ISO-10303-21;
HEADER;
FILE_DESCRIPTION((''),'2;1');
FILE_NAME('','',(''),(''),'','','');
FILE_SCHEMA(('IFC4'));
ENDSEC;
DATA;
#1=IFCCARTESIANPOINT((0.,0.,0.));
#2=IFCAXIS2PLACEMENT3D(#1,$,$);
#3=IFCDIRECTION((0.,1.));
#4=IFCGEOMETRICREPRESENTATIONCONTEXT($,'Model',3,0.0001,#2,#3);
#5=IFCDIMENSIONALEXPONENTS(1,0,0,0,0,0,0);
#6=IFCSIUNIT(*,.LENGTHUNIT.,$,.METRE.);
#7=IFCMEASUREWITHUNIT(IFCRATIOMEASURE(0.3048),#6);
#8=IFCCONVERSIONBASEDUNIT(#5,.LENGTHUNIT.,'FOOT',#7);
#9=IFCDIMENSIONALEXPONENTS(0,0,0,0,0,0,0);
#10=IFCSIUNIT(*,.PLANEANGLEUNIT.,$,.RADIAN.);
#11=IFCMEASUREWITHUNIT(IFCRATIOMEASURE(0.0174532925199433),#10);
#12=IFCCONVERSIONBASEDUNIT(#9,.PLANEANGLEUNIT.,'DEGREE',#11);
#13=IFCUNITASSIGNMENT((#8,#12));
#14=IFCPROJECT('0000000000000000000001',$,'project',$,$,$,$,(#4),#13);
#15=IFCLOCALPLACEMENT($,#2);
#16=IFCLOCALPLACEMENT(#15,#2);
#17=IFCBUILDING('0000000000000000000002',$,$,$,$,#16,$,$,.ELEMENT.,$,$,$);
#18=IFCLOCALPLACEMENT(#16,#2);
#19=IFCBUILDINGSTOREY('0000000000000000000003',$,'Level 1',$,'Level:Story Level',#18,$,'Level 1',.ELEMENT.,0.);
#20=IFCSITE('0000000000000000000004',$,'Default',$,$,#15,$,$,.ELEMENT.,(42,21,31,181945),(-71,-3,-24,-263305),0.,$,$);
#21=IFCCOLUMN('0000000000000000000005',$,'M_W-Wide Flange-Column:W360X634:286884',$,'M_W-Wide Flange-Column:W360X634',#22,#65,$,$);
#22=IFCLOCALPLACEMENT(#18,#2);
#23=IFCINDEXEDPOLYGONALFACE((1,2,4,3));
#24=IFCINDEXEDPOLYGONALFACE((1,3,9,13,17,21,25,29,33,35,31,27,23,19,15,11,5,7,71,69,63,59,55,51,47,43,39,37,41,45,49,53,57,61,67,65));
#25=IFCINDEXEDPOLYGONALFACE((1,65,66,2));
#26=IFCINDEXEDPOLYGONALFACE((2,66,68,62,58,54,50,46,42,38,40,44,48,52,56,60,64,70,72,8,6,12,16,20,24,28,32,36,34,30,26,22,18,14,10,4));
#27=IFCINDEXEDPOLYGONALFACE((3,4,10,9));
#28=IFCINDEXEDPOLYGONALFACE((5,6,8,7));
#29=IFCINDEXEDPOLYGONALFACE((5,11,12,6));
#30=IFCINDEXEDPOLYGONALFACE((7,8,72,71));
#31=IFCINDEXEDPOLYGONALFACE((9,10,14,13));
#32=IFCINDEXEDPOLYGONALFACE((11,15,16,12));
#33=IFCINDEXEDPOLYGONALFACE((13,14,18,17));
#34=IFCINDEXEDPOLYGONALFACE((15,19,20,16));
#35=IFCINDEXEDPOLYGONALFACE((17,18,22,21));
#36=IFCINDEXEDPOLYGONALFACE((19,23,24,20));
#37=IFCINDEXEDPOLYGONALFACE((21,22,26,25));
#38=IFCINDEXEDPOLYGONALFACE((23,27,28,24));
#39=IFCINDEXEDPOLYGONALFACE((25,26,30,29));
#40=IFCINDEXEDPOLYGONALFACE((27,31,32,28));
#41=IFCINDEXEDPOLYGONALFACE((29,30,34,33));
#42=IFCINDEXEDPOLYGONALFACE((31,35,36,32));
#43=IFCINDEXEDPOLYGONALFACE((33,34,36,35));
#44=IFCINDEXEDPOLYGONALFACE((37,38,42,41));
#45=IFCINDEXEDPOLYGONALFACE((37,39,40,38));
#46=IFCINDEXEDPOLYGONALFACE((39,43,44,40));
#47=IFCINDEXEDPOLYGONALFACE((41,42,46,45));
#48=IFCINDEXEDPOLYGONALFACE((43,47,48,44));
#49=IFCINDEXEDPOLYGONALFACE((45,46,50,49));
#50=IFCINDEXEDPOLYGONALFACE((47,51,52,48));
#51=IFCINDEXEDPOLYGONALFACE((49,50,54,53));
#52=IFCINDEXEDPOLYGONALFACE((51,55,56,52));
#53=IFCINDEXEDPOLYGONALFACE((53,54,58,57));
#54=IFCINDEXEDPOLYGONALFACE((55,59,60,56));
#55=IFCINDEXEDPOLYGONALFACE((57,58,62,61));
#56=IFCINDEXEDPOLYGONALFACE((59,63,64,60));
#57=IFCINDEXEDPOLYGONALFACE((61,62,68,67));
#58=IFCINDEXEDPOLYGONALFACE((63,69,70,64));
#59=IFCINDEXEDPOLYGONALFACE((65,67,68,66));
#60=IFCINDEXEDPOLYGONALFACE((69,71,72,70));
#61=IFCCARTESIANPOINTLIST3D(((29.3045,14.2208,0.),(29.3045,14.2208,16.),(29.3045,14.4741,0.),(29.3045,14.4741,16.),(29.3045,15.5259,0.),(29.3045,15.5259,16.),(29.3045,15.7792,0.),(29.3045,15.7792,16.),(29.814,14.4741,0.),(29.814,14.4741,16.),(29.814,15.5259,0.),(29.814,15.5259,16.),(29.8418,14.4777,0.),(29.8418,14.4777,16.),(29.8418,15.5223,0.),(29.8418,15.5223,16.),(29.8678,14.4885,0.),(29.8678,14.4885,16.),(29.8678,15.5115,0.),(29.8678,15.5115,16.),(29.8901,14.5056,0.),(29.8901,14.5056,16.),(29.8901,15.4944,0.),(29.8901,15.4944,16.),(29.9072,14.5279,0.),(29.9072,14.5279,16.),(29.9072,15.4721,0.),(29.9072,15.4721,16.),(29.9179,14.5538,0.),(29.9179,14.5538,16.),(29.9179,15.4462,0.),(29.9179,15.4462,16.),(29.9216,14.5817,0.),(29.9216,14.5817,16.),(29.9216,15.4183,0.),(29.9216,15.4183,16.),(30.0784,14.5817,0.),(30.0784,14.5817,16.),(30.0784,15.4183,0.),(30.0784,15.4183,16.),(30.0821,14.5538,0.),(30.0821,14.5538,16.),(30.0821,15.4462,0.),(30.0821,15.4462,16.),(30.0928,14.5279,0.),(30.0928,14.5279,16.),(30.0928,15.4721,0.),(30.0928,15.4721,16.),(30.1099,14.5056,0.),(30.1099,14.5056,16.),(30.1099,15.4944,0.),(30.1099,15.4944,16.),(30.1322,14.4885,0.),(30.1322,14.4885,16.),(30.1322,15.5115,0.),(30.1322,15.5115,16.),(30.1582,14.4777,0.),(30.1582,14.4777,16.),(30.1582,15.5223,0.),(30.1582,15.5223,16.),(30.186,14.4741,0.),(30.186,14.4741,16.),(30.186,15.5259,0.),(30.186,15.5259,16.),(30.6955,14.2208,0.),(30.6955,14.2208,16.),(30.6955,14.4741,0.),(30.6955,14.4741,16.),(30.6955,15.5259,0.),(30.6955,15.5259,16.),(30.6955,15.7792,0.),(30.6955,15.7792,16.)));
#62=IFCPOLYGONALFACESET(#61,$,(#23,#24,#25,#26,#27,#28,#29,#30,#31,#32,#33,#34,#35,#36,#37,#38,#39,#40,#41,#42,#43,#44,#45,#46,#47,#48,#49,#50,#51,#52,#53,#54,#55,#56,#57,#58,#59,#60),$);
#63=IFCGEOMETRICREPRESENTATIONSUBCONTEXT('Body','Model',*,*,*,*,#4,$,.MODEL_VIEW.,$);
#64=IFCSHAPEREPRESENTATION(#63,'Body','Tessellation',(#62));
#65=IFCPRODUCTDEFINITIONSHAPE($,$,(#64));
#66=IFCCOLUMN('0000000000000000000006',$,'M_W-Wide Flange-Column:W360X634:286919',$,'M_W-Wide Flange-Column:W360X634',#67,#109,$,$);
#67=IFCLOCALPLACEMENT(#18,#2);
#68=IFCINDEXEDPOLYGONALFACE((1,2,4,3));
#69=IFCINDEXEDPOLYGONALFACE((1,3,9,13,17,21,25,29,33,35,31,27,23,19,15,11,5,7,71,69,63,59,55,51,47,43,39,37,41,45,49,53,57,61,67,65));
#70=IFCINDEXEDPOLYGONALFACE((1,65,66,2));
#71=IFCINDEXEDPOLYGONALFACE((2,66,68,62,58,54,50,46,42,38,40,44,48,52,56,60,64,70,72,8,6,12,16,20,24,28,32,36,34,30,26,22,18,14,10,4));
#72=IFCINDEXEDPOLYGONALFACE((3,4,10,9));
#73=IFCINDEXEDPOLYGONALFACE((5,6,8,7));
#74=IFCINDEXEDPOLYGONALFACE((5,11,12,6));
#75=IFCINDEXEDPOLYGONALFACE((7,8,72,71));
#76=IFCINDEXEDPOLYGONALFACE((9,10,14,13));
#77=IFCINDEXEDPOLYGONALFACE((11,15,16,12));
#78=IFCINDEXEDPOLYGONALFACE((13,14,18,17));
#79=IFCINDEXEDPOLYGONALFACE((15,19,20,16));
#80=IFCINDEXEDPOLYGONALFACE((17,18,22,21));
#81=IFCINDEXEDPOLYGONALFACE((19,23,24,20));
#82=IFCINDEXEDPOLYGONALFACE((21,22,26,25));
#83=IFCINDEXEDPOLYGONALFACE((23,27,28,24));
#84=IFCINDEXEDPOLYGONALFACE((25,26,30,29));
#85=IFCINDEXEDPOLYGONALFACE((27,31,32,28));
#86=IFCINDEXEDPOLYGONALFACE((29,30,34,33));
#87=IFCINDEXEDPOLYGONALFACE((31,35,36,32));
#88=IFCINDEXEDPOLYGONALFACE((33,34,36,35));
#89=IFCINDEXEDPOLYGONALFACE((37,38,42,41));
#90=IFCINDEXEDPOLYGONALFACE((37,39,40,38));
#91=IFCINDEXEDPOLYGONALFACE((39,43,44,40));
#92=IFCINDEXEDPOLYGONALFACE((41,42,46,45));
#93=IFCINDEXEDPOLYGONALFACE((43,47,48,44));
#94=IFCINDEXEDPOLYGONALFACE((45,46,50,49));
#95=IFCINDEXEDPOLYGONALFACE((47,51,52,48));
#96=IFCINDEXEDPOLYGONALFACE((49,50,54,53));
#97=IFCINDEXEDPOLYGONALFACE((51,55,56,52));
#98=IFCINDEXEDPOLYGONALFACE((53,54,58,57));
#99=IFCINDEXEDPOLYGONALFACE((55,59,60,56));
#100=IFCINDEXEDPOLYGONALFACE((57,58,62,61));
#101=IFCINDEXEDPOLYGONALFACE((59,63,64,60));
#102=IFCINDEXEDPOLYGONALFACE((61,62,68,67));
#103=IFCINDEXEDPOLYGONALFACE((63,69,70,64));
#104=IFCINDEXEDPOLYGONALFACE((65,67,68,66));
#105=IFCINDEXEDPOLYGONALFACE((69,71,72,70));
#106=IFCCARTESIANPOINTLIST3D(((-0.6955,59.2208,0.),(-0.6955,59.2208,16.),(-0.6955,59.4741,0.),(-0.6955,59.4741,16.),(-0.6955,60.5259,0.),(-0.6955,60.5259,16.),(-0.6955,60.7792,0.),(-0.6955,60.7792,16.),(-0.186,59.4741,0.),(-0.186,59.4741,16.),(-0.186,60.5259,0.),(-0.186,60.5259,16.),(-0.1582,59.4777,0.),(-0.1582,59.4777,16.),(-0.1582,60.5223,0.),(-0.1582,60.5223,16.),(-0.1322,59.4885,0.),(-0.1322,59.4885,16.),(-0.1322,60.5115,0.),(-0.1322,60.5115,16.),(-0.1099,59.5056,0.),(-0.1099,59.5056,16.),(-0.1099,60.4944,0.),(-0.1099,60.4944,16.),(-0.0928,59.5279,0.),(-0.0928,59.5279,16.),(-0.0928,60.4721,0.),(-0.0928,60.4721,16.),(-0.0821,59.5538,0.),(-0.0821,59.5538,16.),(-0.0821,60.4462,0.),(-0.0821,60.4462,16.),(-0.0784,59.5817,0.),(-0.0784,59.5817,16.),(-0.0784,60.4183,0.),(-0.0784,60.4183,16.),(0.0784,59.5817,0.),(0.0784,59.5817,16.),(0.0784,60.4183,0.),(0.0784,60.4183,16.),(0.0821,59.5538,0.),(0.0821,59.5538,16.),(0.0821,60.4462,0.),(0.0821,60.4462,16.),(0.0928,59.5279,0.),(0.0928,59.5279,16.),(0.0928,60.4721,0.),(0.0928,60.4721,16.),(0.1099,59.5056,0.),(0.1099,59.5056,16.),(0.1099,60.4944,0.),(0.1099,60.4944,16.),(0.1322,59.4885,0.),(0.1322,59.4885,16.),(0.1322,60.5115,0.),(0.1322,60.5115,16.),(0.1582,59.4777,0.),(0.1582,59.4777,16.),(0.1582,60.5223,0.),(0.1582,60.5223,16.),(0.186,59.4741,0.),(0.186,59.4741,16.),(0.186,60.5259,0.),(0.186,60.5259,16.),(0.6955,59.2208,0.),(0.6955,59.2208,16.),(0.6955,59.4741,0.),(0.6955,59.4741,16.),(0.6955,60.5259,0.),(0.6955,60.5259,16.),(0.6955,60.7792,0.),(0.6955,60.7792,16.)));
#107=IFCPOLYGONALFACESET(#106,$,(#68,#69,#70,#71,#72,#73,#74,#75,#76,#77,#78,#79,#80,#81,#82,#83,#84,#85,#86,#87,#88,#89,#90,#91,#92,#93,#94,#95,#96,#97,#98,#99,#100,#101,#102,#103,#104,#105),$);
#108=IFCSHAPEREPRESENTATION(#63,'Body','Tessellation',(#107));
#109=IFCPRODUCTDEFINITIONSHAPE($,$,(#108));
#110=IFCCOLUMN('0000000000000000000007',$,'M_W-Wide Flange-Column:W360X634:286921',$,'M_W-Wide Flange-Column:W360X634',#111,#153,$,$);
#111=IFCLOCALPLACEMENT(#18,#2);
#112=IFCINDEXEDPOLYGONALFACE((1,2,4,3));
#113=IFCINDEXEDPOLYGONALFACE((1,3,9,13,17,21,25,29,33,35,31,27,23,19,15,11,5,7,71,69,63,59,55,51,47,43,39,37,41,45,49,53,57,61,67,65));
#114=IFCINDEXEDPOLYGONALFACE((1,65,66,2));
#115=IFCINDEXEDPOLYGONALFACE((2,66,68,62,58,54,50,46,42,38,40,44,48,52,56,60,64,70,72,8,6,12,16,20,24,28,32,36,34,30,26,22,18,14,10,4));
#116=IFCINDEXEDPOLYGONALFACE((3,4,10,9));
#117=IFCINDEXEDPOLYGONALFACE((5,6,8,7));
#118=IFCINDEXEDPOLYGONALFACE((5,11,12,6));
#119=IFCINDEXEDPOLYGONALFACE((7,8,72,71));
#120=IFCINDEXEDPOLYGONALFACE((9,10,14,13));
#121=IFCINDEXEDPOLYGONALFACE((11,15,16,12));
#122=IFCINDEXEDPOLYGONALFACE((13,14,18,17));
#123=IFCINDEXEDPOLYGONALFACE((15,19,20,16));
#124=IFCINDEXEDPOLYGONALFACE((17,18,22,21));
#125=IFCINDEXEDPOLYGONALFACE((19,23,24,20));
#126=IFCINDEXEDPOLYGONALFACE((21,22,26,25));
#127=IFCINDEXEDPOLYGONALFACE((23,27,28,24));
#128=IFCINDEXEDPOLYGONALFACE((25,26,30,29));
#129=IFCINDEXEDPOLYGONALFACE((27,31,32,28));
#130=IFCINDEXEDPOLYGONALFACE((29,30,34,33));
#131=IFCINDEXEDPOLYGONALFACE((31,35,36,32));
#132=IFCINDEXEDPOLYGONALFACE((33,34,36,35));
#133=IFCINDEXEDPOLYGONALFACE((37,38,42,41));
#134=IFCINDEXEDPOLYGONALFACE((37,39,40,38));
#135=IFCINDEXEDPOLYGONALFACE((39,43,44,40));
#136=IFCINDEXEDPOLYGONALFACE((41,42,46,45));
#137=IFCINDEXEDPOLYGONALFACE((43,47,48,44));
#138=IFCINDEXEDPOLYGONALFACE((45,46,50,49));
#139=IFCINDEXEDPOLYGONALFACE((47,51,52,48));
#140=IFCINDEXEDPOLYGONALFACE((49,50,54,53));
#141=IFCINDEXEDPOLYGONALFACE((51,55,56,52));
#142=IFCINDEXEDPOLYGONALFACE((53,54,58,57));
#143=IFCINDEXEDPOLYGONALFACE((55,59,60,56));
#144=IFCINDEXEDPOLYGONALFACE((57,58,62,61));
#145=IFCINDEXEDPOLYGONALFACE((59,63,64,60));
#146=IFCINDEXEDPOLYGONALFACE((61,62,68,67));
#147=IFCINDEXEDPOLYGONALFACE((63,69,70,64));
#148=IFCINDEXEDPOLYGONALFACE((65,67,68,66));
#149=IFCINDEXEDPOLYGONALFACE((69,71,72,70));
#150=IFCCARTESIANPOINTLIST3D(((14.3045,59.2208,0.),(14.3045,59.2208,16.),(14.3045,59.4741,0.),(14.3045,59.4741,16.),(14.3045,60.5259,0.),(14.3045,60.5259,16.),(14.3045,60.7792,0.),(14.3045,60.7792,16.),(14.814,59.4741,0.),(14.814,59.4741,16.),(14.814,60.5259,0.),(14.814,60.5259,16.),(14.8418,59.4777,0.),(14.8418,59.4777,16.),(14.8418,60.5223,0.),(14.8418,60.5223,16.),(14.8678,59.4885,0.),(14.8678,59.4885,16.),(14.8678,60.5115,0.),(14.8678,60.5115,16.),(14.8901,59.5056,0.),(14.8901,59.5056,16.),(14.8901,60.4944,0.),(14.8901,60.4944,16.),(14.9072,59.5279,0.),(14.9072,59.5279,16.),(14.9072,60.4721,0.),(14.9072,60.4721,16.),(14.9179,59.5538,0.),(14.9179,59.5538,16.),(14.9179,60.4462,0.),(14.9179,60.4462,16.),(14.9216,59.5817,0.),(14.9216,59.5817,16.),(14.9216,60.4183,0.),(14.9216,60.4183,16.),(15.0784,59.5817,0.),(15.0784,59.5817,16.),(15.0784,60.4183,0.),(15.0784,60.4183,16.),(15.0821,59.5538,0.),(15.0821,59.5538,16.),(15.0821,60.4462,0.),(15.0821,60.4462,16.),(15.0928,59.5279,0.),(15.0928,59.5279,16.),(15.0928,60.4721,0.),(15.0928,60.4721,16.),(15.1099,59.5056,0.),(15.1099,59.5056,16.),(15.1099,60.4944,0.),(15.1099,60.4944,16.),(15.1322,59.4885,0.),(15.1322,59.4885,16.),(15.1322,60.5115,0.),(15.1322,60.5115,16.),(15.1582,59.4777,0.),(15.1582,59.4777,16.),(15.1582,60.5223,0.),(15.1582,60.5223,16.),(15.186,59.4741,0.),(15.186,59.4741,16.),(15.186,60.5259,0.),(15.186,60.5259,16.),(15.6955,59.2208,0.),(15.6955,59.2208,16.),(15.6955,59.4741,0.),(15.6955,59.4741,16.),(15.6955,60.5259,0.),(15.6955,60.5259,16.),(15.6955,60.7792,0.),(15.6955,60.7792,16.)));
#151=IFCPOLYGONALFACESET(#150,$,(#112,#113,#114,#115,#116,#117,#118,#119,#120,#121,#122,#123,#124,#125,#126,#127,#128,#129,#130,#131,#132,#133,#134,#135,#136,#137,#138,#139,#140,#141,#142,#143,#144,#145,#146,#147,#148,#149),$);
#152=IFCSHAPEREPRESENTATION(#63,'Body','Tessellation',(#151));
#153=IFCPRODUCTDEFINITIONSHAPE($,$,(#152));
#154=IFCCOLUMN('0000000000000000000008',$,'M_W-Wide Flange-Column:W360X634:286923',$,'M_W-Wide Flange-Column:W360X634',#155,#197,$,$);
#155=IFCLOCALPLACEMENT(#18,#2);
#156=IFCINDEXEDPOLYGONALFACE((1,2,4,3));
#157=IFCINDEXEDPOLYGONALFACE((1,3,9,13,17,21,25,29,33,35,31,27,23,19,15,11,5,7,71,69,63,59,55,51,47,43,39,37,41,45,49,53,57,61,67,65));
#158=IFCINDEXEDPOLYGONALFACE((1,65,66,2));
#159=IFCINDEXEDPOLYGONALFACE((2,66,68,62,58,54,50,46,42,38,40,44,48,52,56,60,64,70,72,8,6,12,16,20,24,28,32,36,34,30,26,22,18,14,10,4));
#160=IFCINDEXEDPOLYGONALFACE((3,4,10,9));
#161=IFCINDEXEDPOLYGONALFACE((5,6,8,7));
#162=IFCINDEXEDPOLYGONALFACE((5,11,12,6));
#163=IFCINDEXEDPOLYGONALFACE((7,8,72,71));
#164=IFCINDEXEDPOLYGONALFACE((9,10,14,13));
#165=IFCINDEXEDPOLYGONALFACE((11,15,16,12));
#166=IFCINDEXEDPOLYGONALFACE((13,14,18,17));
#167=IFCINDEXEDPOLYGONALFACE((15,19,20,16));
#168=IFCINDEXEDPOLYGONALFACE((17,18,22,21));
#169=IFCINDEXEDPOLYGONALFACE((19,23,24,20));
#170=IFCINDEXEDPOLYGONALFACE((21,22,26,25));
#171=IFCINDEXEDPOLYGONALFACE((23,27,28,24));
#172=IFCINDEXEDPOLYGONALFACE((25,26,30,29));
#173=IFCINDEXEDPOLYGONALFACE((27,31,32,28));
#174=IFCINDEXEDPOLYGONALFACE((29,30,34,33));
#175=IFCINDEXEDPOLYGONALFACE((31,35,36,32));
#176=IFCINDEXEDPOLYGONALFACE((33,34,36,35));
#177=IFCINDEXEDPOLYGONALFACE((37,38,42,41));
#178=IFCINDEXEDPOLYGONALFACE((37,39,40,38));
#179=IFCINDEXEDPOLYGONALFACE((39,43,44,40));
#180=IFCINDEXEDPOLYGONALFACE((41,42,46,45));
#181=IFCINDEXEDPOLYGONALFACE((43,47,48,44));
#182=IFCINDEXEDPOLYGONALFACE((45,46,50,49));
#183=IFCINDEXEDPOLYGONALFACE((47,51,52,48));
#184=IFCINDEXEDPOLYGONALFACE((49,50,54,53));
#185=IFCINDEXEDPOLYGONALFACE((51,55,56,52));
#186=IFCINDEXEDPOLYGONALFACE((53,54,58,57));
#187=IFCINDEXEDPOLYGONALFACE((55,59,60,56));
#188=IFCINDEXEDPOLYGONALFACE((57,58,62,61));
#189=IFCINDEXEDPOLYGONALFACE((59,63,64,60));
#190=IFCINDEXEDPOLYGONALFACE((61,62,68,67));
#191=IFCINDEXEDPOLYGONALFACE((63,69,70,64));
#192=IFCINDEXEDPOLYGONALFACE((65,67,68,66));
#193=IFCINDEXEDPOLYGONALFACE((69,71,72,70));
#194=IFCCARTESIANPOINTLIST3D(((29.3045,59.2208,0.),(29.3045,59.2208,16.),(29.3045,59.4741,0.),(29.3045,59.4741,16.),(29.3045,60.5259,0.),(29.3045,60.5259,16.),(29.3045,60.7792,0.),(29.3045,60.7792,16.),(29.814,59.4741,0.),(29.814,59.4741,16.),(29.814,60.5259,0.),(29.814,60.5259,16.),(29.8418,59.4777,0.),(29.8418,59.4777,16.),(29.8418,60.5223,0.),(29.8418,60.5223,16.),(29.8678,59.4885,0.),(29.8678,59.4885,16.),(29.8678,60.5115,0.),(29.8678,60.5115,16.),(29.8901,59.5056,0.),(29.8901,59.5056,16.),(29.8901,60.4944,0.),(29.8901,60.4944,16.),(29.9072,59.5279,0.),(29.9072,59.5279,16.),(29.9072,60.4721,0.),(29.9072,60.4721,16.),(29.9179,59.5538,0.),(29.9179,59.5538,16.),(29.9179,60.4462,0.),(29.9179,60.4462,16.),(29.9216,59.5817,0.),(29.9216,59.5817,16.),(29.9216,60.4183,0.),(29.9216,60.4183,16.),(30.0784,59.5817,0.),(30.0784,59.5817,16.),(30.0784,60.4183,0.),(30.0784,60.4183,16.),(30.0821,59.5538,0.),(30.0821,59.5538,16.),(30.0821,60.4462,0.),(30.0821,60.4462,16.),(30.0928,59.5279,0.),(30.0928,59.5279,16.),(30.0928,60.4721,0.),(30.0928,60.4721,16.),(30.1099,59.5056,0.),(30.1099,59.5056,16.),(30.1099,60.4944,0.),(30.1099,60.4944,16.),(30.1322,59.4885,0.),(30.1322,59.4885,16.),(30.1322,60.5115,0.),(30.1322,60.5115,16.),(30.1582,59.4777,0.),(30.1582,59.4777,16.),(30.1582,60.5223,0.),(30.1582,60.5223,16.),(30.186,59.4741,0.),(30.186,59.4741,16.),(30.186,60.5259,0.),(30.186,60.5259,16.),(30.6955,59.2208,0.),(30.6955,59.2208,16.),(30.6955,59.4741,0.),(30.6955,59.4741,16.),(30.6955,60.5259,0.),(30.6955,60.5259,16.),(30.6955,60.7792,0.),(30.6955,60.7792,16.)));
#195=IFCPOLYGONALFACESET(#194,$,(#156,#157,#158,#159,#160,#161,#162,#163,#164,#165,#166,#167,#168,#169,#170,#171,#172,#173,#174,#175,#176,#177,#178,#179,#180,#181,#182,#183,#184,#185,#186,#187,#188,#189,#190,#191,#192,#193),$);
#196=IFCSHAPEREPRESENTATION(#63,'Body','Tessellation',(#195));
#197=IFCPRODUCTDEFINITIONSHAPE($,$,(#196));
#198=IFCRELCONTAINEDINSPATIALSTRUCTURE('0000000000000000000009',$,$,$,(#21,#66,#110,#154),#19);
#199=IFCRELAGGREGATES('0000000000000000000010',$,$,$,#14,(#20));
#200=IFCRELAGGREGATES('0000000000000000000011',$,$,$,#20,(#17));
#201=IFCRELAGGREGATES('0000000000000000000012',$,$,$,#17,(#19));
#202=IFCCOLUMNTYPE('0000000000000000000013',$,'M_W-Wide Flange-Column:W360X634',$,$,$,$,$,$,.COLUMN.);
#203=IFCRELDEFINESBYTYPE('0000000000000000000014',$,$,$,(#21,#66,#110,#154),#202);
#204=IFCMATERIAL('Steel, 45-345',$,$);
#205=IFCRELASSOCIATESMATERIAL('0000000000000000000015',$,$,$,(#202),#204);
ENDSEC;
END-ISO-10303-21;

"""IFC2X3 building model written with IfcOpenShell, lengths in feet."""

from ifc_helpers import new_model, entity, si_unit, converted_unit, direction, frame, frame_2d, origin, place, context, subcontext, project, spatial, polyline, circle_curve, parameter, trimmed, segment, composite_curve, outline, extrude, source, transform, mapped, material, type_object, type_shapes, element, save


model = new_model("IFC2X3")

# Units and contexts
model_context = context("Model", 3, precision=0.0001, world=origin(), true_north=direction((0.0, 1.0)))
body_context = subcontext(model_context, "Body", "Model", "MODEL_VIEW")
ifc_project = project(units=[converted_unit("LENGTHUNIT", "FOOT", entity("IfcRatioMeasure", 0.3048), si_unit("LENGTHUNIT", "METRE"), dimensions=[1, 0, 0, 0, 0, 0, 0]), converted_unit("PLANEANGLEUNIT", "DEGREE", entity("IfcRatioMeasure", 0.0174532925199433), si_unit("PLANEANGLEUNIT", "RADIAN"), dimensions=[0, 0, 0, 0, 0, 0, 0])], contexts=[model_context])

# Site, building, storey
site_placement = place(None, origin())
site = spatial("IfcSite", under=ifc_project, at=site_placement, Name="Default", CompositionType="ELEMENT", RefLatitude=(42, 21, 31, 181945), RefLongitude=(-71, -3, -24, -263305), RefElevation=0.0)
building_placement = place(site_placement, origin())
building = spatial("IfcBuilding", under=site, at=building_placement, CompositionType="ELEMENT")
storey_placement = place(building_placement, origin())
storey = spatial("IfcBuildingStorey", under=building, at=storey_placement, Name="Level 1", ObjectType="Level:Story Level", LongName="Level 1", CompositionType="ELEMENT", Elevation=0.0)

# Columns
ifc_material = material(Name="Steel, 45-345")
column_type = type_object("IfcColumnType", Name="M_W-Wide Flange-Column:W360X634", PredefinedType="COLUMN", material=ifc_material)
shared_shape = source(origin(), body_context, "Body", "SweptSolid", [
    extrude(outline(composite_curve([segment(polyline([(0.5259, -0.6955), (0.7792, -0.6955)]), True, "CONTINUOUS"), segment(polyline([(0.7792, -0.6955), (0.7792, 0.6955)]), True, "CONTINUOUS"), segment(polyline([(0.7792, 0.6955), (0.5259, 0.6955)]), True, "CONTINUOUS"), segment(polyline([(0.5259, 0.6955), (0.5259, 0.186)]), True, "CONTINUOUS"), segment(trimmed(circle_curve(frame_2d((0.4183, 0.186), x_axis=(1.0, 0.0)), 0.1076), [parameter(270.0)], [parameter(0.0)], True, "PARAMETER"), False, "CONTINUOUS"), segment(polyline([(0.4183, 0.0784), (-0.4183, 0.0784)]), True, "CONTINUOUS"), segment(trimmed(circle_curve(frame_2d((-0.4183, 0.186), x_axis=(0.0, -1.0)), 0.1076), [parameter(270.0)], [parameter(0.0)], True, "PARAMETER"), False, "CONTINUOUS"), segment(polyline([(-0.5259, 0.186), (-0.5259, 0.6955)]), True, "CONTINUOUS"), segment(polyline([(-0.5259, 0.6955), (-0.7792, 0.6955)]), True, "CONTINUOUS"), segment(polyline([(-0.7792, 0.6955), (-0.7792, -0.6955)]), True, "CONTINUOUS"), segment(polyline([(-0.7792, -0.6955), (-0.5259, -0.6955)]), True, "CONTINUOUS"), segment(polyline([(-0.5259, -0.6955), (-0.5259, -0.186)]), True, "CONTINUOUS"), segment(trimmed(circle_curve(frame_2d((-0.4183, -0.186), x_axis=(-1.0, 0.0)), 0.1076), [parameter(270.0)], [parameter(0.0)], True, "PARAMETER"), False, "CONTINUOUS"), segment(polyline([(-0.4183, -0.0784), (0.4183, -0.0784)]), True, "CONTINUOUS"), segment(trimmed(circle_curve(frame_2d((0.4183, -0.186), x_axis=(0.0, 1.0)), 0.1076), [parameter(270.0)], [parameter(0.0)], True, "PARAMETER"), False, "CONTINUOUS"), segment(polyline([(0.5259, -0.186), (0.5259, -0.6955)]), True, "CONTINUOUS")], self_intersect=False)), frame((0.0, 0.0, 0.0), z_axis=(0.0, 0.0, 1.0), x_axis=(0.0, -1.0, 0.0)), (0.0, 0.0, 1.0), 16.0),
])
type_shapes(column_type, [shared_shape])
for number, where, name in (
    (1, (30.0, 15.0, 0.0), "M_W-Wide Flange-Column:W360X634:286884"),
    (2, (0.0, 60.0, 0.0), "M_W-Wide Flange-Column:W360X634:286919"),
    (3, (15.0, 60.0, 0.0), "M_W-Wide Flange-Column:W360X634:286921"),
    (4, (30.0, 60.0, 0.0), "M_W-Wide Flange-Column:W360X634:286923"),
):
    element("IfcColumn", number, at=place(storey_placement, frame(where)), inside=storey, type_object=column_type, Name=name, ObjectType="M_W-Wide Flange-Column:W360X634", context=body_context, shape_type="MappedRepresentation", body=[
        mapped(shared_shape, transform((0.0, 0.0, 0.0), scale=1.0)),
    ])

save(model, "model.ifc")
